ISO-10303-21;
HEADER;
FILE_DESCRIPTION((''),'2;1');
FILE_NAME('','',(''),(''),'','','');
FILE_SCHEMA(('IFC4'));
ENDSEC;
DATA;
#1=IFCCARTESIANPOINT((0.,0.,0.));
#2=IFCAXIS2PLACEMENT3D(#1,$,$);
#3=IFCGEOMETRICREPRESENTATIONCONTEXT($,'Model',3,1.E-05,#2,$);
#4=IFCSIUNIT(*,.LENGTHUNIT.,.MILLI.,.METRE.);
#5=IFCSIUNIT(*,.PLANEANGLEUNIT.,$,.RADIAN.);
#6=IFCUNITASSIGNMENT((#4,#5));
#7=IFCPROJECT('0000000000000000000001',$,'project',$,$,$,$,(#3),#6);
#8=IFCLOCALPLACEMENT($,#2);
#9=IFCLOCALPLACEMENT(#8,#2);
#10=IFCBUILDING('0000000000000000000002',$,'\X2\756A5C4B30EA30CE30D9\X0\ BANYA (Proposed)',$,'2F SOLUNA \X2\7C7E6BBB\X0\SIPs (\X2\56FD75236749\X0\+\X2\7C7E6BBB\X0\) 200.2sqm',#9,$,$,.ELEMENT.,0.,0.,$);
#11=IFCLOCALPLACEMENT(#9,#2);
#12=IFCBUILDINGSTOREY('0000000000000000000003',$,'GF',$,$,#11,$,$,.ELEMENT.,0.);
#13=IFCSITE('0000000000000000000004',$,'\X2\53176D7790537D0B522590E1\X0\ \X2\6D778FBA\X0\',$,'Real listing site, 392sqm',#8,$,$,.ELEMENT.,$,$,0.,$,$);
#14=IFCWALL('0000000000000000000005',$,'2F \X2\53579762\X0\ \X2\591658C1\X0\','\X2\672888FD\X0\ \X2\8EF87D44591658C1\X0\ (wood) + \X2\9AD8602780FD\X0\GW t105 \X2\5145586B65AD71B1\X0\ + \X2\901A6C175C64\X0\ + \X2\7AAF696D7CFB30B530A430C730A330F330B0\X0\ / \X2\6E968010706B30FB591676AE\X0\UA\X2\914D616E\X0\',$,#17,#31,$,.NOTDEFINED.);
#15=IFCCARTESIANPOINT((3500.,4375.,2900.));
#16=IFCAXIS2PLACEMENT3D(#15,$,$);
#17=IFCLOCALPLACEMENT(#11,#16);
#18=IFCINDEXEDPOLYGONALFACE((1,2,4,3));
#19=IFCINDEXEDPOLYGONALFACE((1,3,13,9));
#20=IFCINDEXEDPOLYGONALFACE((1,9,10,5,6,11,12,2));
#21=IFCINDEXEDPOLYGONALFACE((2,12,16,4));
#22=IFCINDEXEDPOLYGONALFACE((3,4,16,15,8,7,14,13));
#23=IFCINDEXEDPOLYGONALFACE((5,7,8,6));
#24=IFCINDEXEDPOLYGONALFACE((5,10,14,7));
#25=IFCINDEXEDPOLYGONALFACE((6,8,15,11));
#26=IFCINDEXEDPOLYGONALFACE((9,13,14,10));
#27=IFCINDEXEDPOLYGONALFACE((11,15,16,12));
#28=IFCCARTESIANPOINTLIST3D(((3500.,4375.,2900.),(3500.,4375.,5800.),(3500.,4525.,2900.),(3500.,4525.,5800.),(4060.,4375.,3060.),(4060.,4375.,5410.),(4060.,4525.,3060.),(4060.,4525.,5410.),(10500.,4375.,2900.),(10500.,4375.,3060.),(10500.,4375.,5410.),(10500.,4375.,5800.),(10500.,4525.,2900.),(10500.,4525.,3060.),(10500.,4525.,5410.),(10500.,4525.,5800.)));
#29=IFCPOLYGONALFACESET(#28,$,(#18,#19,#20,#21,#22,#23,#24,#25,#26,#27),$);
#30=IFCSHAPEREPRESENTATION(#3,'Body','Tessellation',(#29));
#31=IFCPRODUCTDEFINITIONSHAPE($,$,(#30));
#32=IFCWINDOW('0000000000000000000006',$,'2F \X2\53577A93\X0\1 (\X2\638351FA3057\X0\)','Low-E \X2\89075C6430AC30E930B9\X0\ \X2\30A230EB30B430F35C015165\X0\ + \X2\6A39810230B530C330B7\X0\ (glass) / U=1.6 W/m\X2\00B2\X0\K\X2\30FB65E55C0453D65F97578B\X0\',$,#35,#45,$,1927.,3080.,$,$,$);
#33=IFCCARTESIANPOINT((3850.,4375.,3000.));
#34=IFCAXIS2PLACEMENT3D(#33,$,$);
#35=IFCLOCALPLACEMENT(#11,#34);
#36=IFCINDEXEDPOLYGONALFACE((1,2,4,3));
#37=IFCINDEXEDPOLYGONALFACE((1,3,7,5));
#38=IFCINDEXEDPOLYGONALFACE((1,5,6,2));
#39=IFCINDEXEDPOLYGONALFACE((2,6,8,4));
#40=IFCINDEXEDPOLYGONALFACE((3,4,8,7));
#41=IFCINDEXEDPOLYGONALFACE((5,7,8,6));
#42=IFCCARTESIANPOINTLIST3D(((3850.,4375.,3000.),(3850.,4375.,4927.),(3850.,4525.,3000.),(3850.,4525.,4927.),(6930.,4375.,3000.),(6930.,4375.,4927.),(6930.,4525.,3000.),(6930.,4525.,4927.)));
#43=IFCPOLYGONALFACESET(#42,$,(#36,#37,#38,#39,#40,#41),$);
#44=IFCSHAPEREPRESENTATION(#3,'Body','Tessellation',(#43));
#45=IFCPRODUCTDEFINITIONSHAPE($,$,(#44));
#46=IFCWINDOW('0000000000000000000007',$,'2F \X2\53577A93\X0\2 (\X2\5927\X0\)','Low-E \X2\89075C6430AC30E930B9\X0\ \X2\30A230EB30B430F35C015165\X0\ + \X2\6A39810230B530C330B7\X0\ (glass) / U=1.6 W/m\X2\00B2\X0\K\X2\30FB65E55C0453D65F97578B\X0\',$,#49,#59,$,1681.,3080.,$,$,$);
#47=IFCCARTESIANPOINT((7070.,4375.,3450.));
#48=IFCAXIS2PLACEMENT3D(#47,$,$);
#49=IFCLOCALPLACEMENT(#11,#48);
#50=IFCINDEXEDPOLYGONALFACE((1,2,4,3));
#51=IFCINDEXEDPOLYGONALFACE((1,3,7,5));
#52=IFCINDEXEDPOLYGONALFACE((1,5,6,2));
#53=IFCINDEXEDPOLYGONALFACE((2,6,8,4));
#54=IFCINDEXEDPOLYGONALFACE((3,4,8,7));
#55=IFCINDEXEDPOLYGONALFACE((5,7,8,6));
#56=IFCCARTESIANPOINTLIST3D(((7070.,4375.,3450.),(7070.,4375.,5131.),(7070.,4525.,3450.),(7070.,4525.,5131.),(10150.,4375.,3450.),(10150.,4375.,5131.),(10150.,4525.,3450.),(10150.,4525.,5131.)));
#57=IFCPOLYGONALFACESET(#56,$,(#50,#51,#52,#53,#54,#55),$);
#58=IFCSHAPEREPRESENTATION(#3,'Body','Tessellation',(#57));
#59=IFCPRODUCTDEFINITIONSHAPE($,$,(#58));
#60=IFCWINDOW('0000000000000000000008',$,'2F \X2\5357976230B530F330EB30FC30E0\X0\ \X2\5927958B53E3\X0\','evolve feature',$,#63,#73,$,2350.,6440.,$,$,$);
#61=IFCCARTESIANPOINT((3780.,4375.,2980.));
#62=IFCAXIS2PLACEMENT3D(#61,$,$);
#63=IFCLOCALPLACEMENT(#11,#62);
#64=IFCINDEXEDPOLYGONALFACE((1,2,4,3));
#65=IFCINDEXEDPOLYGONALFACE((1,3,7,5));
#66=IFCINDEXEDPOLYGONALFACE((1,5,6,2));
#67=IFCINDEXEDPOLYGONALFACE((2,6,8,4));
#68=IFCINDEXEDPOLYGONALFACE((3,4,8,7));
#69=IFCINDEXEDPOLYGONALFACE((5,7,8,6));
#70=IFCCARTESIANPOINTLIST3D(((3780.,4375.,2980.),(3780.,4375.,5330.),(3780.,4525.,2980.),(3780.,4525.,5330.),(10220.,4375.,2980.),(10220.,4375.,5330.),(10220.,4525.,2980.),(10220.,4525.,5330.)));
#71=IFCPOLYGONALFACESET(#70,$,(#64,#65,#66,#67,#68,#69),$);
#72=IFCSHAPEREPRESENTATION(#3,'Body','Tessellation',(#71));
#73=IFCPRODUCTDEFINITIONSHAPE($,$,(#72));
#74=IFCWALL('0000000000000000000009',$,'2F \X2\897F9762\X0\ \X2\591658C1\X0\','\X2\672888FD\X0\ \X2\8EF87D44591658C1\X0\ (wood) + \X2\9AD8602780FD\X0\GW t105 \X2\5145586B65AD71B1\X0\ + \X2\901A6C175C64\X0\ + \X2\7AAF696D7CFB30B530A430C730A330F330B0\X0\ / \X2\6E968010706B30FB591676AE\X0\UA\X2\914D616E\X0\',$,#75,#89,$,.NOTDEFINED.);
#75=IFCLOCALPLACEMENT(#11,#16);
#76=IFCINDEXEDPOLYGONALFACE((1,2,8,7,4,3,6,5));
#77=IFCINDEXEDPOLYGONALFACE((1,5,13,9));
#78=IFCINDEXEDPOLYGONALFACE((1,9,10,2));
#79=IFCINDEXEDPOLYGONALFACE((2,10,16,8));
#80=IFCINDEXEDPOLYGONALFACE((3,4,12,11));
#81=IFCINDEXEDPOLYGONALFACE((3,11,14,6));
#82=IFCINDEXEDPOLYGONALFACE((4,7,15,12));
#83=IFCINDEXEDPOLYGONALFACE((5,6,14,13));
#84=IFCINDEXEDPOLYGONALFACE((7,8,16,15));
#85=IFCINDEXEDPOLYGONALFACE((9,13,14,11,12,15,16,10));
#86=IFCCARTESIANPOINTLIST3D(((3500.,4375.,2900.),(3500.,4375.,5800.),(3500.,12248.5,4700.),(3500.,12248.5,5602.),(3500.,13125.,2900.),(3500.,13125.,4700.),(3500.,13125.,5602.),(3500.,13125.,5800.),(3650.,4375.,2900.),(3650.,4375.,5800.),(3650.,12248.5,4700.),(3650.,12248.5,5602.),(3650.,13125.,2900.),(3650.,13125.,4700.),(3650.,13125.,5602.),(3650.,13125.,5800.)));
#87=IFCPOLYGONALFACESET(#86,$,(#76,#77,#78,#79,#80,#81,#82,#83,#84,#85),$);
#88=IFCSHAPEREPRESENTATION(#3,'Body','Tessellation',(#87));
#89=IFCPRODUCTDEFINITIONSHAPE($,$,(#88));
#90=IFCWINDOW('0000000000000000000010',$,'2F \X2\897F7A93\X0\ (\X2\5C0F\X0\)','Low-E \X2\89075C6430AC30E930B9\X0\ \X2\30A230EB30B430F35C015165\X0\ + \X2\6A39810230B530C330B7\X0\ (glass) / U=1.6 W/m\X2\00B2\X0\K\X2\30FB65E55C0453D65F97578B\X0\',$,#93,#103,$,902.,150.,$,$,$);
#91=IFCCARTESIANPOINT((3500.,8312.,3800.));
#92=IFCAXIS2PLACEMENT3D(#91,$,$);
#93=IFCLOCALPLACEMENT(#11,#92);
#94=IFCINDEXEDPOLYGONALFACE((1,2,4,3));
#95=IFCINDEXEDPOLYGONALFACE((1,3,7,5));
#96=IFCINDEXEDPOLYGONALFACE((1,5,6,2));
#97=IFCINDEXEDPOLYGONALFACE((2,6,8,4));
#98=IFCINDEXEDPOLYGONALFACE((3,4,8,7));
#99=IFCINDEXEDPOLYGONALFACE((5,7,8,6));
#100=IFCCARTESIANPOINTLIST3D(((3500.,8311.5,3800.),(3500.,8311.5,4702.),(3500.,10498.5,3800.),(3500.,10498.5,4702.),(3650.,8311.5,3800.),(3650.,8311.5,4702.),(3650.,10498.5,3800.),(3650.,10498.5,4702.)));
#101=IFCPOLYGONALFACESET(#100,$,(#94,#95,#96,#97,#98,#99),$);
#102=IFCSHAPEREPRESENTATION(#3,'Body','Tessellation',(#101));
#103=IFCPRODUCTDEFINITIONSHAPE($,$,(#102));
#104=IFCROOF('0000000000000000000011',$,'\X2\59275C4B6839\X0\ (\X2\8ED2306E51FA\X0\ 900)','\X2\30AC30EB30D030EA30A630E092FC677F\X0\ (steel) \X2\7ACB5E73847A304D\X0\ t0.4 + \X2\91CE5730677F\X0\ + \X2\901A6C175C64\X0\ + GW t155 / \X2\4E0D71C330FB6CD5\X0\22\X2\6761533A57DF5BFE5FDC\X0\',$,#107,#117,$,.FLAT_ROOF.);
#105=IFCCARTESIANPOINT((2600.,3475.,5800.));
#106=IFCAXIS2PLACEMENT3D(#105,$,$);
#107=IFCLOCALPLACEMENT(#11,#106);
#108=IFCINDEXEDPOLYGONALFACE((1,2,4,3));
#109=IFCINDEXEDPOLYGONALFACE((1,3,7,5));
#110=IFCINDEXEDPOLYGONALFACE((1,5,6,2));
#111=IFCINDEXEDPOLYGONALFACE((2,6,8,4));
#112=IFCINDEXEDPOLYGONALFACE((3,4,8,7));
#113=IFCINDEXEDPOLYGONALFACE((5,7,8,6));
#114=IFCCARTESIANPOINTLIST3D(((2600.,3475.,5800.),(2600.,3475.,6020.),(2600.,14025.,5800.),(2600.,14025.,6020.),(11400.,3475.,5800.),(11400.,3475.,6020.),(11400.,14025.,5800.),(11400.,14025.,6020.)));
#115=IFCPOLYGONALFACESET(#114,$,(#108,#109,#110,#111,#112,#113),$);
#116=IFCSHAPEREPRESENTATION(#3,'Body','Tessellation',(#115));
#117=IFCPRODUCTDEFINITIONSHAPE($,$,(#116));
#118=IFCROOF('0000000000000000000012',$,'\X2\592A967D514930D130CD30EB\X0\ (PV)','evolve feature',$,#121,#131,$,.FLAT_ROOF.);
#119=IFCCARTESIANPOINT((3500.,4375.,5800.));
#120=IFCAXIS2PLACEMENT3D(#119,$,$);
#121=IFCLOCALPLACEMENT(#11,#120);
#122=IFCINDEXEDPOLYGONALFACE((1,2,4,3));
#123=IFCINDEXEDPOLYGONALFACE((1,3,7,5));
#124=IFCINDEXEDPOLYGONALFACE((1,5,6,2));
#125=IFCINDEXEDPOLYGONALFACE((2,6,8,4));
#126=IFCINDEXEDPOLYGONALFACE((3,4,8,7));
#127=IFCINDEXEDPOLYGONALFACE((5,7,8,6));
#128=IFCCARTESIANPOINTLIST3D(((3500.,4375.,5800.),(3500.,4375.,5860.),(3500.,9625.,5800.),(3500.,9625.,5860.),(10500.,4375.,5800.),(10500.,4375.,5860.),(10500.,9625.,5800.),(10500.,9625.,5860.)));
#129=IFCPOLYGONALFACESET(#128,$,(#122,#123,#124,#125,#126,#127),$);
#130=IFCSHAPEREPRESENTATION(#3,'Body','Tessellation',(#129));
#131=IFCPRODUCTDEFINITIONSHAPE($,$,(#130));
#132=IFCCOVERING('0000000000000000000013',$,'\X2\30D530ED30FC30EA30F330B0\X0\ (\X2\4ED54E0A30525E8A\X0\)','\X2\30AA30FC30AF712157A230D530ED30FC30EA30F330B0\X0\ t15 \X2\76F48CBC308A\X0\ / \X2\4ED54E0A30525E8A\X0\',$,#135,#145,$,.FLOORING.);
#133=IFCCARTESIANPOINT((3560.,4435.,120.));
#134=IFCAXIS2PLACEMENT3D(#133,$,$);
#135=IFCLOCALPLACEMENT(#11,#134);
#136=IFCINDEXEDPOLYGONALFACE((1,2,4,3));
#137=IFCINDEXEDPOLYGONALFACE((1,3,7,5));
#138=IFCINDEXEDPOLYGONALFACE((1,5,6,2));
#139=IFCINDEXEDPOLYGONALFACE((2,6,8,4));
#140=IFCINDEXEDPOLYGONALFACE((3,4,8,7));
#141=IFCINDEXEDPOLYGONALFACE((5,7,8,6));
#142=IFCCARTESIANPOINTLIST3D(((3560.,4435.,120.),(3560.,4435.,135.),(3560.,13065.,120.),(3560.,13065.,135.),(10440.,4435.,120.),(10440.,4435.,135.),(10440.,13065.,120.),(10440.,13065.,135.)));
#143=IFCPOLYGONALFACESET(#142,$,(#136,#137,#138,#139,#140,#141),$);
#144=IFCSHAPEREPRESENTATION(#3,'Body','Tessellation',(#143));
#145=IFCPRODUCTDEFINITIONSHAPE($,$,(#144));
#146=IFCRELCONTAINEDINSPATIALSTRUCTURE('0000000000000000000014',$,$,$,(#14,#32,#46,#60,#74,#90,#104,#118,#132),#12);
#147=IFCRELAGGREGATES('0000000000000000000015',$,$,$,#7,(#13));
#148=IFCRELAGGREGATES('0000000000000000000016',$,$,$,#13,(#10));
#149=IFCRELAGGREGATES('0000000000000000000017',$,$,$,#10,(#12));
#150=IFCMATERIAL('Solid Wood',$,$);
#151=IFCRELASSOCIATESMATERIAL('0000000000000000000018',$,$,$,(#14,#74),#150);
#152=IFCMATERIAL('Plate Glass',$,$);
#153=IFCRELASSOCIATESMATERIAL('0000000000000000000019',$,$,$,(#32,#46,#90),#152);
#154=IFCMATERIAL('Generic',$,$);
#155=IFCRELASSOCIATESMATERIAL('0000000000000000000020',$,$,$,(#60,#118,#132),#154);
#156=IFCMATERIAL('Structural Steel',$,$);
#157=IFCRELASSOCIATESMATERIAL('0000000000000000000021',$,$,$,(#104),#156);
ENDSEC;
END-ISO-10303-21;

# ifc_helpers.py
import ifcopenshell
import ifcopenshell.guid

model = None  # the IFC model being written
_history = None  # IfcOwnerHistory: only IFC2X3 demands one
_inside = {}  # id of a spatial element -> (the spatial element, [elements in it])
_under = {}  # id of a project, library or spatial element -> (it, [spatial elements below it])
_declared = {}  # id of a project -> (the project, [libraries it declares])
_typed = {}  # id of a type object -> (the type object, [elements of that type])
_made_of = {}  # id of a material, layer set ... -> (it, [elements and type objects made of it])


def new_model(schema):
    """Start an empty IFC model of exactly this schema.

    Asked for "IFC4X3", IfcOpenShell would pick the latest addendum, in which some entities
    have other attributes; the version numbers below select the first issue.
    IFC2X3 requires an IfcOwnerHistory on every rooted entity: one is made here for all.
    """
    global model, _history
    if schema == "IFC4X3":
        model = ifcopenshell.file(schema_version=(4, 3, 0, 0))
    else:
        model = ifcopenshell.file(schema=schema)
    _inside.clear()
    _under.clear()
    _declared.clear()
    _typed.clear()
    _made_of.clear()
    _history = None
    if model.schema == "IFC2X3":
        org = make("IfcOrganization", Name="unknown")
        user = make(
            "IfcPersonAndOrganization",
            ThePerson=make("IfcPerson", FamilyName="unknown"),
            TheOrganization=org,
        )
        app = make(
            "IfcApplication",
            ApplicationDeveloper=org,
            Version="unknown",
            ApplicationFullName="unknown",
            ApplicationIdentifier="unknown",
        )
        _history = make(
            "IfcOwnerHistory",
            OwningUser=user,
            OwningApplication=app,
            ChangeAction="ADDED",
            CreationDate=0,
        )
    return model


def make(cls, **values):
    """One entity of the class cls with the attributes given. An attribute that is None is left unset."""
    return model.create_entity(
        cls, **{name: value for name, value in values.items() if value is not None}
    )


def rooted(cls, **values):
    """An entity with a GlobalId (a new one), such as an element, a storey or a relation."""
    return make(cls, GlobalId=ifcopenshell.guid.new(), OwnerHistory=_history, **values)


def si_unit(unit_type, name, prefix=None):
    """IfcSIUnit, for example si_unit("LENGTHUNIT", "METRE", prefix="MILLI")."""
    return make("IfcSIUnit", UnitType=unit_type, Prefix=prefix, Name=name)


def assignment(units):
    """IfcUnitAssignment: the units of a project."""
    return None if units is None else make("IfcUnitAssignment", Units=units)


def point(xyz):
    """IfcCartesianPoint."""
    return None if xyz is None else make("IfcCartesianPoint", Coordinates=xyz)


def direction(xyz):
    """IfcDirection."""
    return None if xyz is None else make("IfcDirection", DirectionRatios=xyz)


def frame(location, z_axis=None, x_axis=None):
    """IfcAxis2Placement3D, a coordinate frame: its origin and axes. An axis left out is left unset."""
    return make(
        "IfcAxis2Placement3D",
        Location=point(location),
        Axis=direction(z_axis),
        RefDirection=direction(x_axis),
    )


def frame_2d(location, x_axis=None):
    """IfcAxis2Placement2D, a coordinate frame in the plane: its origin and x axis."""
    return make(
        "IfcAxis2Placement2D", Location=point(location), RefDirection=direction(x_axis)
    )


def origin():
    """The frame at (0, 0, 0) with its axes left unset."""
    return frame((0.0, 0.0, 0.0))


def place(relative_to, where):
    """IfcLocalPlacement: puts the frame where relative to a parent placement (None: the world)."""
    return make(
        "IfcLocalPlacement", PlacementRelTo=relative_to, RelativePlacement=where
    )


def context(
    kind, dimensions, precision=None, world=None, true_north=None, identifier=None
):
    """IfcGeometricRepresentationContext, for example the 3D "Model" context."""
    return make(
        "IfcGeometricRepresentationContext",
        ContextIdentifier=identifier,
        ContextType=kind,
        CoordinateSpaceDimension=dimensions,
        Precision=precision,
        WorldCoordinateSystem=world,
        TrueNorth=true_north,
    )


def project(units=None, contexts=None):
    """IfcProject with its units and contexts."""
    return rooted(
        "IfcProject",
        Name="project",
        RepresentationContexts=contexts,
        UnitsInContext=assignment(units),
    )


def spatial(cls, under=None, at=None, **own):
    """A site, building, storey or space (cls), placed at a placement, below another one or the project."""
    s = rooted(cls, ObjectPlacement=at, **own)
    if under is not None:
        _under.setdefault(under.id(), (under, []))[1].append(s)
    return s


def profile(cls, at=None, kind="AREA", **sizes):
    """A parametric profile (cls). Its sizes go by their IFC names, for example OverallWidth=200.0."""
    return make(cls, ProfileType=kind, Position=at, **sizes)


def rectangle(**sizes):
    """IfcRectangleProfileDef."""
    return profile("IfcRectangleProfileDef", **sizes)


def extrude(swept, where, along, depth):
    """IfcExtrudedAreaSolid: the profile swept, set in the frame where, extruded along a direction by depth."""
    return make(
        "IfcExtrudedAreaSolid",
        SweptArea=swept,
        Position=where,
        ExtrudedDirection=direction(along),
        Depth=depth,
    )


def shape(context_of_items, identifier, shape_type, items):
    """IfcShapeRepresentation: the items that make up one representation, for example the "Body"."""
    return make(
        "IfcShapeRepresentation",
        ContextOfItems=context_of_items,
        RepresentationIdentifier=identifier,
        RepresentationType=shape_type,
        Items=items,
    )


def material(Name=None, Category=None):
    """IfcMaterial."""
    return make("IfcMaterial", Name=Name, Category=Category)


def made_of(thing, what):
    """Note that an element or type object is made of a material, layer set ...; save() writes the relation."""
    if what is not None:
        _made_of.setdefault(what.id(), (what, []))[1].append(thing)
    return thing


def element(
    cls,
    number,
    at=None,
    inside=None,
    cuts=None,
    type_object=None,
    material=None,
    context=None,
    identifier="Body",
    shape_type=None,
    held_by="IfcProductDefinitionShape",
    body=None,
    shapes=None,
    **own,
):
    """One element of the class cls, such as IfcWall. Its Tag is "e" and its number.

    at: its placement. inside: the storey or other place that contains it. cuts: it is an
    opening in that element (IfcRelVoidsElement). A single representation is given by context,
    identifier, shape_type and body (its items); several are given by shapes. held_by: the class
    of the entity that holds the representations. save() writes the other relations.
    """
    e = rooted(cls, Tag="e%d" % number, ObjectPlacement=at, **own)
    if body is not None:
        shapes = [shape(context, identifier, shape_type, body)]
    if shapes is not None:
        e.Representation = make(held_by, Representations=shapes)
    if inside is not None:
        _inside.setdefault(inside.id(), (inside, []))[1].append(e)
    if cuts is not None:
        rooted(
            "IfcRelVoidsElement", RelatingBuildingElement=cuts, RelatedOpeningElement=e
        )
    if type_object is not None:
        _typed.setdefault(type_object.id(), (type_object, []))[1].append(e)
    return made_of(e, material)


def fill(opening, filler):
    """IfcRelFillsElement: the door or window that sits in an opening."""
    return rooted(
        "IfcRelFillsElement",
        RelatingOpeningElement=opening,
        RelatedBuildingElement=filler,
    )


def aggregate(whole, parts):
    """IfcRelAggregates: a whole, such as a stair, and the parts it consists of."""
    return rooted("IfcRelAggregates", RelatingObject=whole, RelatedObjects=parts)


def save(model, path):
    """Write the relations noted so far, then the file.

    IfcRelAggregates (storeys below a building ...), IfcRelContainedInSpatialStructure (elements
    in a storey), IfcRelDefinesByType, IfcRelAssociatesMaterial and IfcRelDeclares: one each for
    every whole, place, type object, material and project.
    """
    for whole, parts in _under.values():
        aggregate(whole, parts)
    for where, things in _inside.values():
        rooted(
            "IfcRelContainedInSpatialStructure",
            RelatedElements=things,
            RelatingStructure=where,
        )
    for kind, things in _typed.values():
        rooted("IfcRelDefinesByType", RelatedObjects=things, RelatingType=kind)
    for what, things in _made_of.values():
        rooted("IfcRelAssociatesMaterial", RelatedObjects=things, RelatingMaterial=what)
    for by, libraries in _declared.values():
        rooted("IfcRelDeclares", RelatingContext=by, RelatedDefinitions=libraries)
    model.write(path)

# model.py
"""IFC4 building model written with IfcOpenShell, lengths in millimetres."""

from ifc_helpers import new_model, si_unit, frame, frame_2d, origin, place, context, project, spatial, rectangle, extrude, material, element, fill, save


model = new_model("IFC4")

# Units and contexts
model_context = context("Model", 3, precision=1e-05, world=origin())
ifc_project = project(units=[si_unit("LENGTHUNIT", "METRE", prefix="MILLI"), si_unit("PLANEANGLEUNIT", "RADIAN")], contexts=[model_context])

# Site, building, storey
site_placement = place(None, origin())
site = spatial("IfcSite", under=ifc_project, at=site_placement, Name="北海道紋別郡 海辺", ObjectType="Real listing site, 392sqm", CompositionType="ELEMENT", RefElevation=0.0)
building_placement = place(site_placement, origin())
building = spatial("IfcBuilding", under=site, at=building_placement, Name="番屋リノベ BANYA (Proposed)", ObjectType="2F SOLUNA 籾殻SIPs (国産杉+籾殻) 200.2sqm", CompositionType="ELEMENT", ElevationOfRefHeight=0.0, ElevationOfTerrain=0.0)
storey_placement = place(building_placement, origin())
storey = spatial("IfcBuildingStorey", under=building, at=storey_placement, Name="GF", CompositionType="ELEMENT", Elevation=0.0)

# Shared definitions
ifc_material_1 = material(Name="Solid Wood")

# Shared definitions
ifc_material_2 = material(Name="Plate Glass")
ifc_material_3 = material(Name="Generic")

# Wall, openings, windows
wall_1_placement = place(storey_placement, frame((3500.0, 4375.0, 2900.0)))
wall_1 = element("IfcWall", 1, at=wall_1_placement, inside=storey, material=ifc_material_1, Name="2F 南面 外壁", Description="木製 軸組外壁 (wood) + 高性能GW t105 充填断熱 + 通気層 + 窯業系サイディング / 準耐火・外皮UA配慮", PredefinedType="NOTDEFINED", context=model_context, shape_type="SweptSolid", body=[
    extrude(rectangle(XDim=7000.0, YDim=150.0, at=frame_2d((3500.0, 75.0))), frame((3500.0, 4375.0, 2900.0)), (0.0, 0.0, 1.0), 2900.0),
])
opening_1_placement = place(storey_placement, frame((3850.0, 4375.0, 3000.0)))
opening_1 = element("IfcOpeningElement", 2, at=opening_1_placement, cuts=wall_1, PredefinedType="NOTDEFINED", context=model_context, shape_type="SweptSolid", body=[
    extrude(rectangle(XDim=3080.0, YDim=150.0, at=frame_2d((1540.0, 75.0))), frame((3850.0, 4375.0, 3000.0)), (0.0, 0.0, 1.0), 1927.0),
])
opening_2_placement = place(storey_placement, frame((7070.0, 4375.0, 3450.0)))
opening_2 = element("IfcOpeningElement", 3, at=opening_2_placement, cuts=wall_1, PredefinedType="NOTDEFINED", context=model_context, shape_type="SweptSolid", body=[
    extrude(rectangle(XDim=3080.0, YDim=150.0, at=frame_2d((1540.0, 75.0))), frame((7070.0, 4375.0, 3450.0)), (0.0, 0.0, 1.0), 1681.0),
])
opening_3_placement = place(storey_placement, frame((3780.0, 4375.0, 2980.0)))
opening_3 = element("IfcOpeningElement", 4, at=opening_3_placement, cuts=wall_1, PredefinedType="NOTDEFINED", context=model_context, shape_type="SweptSolid", body=[
    extrude(rectangle(XDim=6440.0, YDim=150.0, at=frame_2d((3220.0, 75.0))), frame((3780.0, 4375.0, 2980.0)), (0.0, 0.0, 1.0), 2350.0),
])
window_1_placement = place(storey_placement, frame((3850.0, 4375.0, 3000.0)))
window_1 = element("IfcWindow", 5, at=window_1_placement, inside=storey, material=ifc_material_2, Name="2F 南窓1 (掃出し)", Description="Low-E 複層ガラス アルゴン封入 + 樹脂サッシ (glass) / U=1.6 W/m²K・日射取得型", OverallHeight=1927.0, OverallWidth=3080.0, context=model_context, shape_type="SweptSolid", body=[
    extrude(rectangle(XDim=3080.0, YDim=150.0, at=frame_2d((1540.0, 75.0))), frame((3850.0, 4375.0, 3000.0)), (0.0, 0.0, 1.0), 1927.0),
])
fill(opening_1, window_1)
window_2_placement = place(storey_placement, frame((7070.0, 4375.0, 3450.0)))
window_2 = element("IfcWindow", 6, at=window_2_placement, inside=storey, material=ifc_material_2, Name="2F 南窓2 (大)", Description="Low-E 複層ガラス アルゴン封入 + 樹脂サッシ (glass) / U=1.6 W/m²K・日射取得型", OverallHeight=1681.0, OverallWidth=3080.0, context=model_context, shape_type="SweptSolid", body=[
    extrude(rectangle(XDim=3080.0, YDim=150.0, at=frame_2d((1540.0, 75.0))), frame((7070.0, 4375.0, 3450.0)), (0.0, 0.0, 1.0), 1681.0),
])
fill(opening_2, window_2)
window_3_placement = place(storey_placement, frame((3780.0, 4375.0, 2980.0)))
window_3 = element("IfcWindow", 7, at=window_3_placement, inside=storey, material=ifc_material_3, Name="2F 南面サンルーム 大開口", Description="evolve feature", OverallHeight=2350.0, OverallWidth=6440.0, context=model_context, shape_type="SweptSolid", body=[
    extrude(rectangle(XDim=6440.0, YDim=150.0, at=frame_2d((3220.0, 75.0))), frame((3780.0, 4375.0, 2980.0)), (0.0, 0.0, 1.0), 2350.0),
])
fill(opening_3, window_3)

# Wall, opening, window
wall_2_placement = place(storey_placement, frame((3500.0, 4375.0, 2900.0)))
wall_2 = element("IfcWall", 8, at=wall_2_placement, inside=storey, material=ifc_material_1, Name="2F 西面 外壁", Description="木製 軸組外壁 (wood) + 高性能GW t105 充填断熱 + 通気層 + 窯業系サイディング / 準耐火・外皮UA配慮", PredefinedType="NOTDEFINED", context=model_context, shape_type="SweptSolid", body=[
    extrude(rectangle(XDim=150.0, YDim=8750.0, at=frame_2d((75.0, 4375.0))), frame((3500.0, 4375.0, 2900.0)), (0.0, 0.0, 1.0), 2900.0),
])
opening_4_placement = place(storey_placement, frame((3500.0, 8312.0, 3800.0)))
opening_4 = element("IfcOpeningElement", 9, at=opening_4_placement, cuts=wall_2, PredefinedType="NOTDEFINED", context=model_context, shape_type="SweptSolid", body=[
    extrude(rectangle(XDim=150.0, YDim=2187.0, at=frame_2d((75.0, 1093.0))), frame((3500.0, 8312.0, 3800.0)), (0.0, 0.0, 1.0), 902.0),
])
window_4_placement = place(storey_placement, frame((3500.0, 8312.0, 3800.0)))
window_4 = element("IfcWindow", 10, at=window_4_placement, inside=storey, material=ifc_material_2, Name="2F 西窓 (小)", Description="Low-E 複層ガラス アルゴン封入 + 樹脂サッシ (glass) / U=1.6 W/m²K・日射取得型", OverallHeight=902.0, OverallWidth=150.0, context=model_context, shape_type="SweptSolid", body=[
    extrude(rectangle(XDim=150.0, YDim=2187.0, at=frame_2d((75.0, 1093.0))), frame((3500.0, 8312.0, 3800.0)), (0.0, 0.0, 1.0), 902.0),
])
fill(opening_4, window_4)

# Roofs
ifc_material_4 = material(Name="Structural Steel")
roof_1_placement = place(storey_placement, frame((2600.0, 3475.0, 5800.0)))
element("IfcRoof", 11, at=roof_1_placement, inside=storey, material=ifc_material_4, Name="大屋根 (軒の出 900)", Description="ガルバリウム鋼板 (steel) 立平葺き t0.4 + 野地板 + 通気層 + GW t155 / 不燃・法22条区域対応", PredefinedType="FLAT_ROOF", context=model_context, shape_type="SweptSolid", body=[
    extrude(rectangle(XDim=8800.0, YDim=10550.0, at=frame_2d((4400.0, 5275.0))), frame((2600.0, 3475.0, 5800.0)), (0.0, 0.0, 1.0), 220.0),
])
roof_2_placement = place(storey_placement, frame((3500.0, 4375.0, 5800.0)))
element("IfcRoof", 12, at=roof_2_placement, inside=storey, material=ifc_material_3, Name="太陽光パネル (PV)", Description="evolve feature", PredefinedType="FLAT_ROOF", context=model_context, shape_type="SweptSolid", body=[
    extrude(rectangle(XDim=7000.0, YDim=5250.0, at=frame_2d((3500.0, 2625.0))), frame((3500.0, 4375.0, 5800.0)), (0.0, 0.0, 1.0), 60.0),
])

# Covering
covering_placement = place(storey_placement, frame((3560.0, 4435.0, 120.0)))
element("IfcCovering", 13, at=covering_placement, inside=storey, material=ifc_material_3, Name="フローリング (仕上げ床)", Description="オーク無垢フローリング t15 直貼り / 仕上げ床", PredefinedType="FLOORING", context=model_context, shape_type="SweptSolid", body=[
    extrude(rectangle(XDim=6880.0, YDim=8630.0, at=frame_2d((3440.0, 4315.0))), frame((3560.0, 4435.0, 120.0)), (0.0, 0.0, 1.0), 15.0),
])

save(model, "model.ifc")
